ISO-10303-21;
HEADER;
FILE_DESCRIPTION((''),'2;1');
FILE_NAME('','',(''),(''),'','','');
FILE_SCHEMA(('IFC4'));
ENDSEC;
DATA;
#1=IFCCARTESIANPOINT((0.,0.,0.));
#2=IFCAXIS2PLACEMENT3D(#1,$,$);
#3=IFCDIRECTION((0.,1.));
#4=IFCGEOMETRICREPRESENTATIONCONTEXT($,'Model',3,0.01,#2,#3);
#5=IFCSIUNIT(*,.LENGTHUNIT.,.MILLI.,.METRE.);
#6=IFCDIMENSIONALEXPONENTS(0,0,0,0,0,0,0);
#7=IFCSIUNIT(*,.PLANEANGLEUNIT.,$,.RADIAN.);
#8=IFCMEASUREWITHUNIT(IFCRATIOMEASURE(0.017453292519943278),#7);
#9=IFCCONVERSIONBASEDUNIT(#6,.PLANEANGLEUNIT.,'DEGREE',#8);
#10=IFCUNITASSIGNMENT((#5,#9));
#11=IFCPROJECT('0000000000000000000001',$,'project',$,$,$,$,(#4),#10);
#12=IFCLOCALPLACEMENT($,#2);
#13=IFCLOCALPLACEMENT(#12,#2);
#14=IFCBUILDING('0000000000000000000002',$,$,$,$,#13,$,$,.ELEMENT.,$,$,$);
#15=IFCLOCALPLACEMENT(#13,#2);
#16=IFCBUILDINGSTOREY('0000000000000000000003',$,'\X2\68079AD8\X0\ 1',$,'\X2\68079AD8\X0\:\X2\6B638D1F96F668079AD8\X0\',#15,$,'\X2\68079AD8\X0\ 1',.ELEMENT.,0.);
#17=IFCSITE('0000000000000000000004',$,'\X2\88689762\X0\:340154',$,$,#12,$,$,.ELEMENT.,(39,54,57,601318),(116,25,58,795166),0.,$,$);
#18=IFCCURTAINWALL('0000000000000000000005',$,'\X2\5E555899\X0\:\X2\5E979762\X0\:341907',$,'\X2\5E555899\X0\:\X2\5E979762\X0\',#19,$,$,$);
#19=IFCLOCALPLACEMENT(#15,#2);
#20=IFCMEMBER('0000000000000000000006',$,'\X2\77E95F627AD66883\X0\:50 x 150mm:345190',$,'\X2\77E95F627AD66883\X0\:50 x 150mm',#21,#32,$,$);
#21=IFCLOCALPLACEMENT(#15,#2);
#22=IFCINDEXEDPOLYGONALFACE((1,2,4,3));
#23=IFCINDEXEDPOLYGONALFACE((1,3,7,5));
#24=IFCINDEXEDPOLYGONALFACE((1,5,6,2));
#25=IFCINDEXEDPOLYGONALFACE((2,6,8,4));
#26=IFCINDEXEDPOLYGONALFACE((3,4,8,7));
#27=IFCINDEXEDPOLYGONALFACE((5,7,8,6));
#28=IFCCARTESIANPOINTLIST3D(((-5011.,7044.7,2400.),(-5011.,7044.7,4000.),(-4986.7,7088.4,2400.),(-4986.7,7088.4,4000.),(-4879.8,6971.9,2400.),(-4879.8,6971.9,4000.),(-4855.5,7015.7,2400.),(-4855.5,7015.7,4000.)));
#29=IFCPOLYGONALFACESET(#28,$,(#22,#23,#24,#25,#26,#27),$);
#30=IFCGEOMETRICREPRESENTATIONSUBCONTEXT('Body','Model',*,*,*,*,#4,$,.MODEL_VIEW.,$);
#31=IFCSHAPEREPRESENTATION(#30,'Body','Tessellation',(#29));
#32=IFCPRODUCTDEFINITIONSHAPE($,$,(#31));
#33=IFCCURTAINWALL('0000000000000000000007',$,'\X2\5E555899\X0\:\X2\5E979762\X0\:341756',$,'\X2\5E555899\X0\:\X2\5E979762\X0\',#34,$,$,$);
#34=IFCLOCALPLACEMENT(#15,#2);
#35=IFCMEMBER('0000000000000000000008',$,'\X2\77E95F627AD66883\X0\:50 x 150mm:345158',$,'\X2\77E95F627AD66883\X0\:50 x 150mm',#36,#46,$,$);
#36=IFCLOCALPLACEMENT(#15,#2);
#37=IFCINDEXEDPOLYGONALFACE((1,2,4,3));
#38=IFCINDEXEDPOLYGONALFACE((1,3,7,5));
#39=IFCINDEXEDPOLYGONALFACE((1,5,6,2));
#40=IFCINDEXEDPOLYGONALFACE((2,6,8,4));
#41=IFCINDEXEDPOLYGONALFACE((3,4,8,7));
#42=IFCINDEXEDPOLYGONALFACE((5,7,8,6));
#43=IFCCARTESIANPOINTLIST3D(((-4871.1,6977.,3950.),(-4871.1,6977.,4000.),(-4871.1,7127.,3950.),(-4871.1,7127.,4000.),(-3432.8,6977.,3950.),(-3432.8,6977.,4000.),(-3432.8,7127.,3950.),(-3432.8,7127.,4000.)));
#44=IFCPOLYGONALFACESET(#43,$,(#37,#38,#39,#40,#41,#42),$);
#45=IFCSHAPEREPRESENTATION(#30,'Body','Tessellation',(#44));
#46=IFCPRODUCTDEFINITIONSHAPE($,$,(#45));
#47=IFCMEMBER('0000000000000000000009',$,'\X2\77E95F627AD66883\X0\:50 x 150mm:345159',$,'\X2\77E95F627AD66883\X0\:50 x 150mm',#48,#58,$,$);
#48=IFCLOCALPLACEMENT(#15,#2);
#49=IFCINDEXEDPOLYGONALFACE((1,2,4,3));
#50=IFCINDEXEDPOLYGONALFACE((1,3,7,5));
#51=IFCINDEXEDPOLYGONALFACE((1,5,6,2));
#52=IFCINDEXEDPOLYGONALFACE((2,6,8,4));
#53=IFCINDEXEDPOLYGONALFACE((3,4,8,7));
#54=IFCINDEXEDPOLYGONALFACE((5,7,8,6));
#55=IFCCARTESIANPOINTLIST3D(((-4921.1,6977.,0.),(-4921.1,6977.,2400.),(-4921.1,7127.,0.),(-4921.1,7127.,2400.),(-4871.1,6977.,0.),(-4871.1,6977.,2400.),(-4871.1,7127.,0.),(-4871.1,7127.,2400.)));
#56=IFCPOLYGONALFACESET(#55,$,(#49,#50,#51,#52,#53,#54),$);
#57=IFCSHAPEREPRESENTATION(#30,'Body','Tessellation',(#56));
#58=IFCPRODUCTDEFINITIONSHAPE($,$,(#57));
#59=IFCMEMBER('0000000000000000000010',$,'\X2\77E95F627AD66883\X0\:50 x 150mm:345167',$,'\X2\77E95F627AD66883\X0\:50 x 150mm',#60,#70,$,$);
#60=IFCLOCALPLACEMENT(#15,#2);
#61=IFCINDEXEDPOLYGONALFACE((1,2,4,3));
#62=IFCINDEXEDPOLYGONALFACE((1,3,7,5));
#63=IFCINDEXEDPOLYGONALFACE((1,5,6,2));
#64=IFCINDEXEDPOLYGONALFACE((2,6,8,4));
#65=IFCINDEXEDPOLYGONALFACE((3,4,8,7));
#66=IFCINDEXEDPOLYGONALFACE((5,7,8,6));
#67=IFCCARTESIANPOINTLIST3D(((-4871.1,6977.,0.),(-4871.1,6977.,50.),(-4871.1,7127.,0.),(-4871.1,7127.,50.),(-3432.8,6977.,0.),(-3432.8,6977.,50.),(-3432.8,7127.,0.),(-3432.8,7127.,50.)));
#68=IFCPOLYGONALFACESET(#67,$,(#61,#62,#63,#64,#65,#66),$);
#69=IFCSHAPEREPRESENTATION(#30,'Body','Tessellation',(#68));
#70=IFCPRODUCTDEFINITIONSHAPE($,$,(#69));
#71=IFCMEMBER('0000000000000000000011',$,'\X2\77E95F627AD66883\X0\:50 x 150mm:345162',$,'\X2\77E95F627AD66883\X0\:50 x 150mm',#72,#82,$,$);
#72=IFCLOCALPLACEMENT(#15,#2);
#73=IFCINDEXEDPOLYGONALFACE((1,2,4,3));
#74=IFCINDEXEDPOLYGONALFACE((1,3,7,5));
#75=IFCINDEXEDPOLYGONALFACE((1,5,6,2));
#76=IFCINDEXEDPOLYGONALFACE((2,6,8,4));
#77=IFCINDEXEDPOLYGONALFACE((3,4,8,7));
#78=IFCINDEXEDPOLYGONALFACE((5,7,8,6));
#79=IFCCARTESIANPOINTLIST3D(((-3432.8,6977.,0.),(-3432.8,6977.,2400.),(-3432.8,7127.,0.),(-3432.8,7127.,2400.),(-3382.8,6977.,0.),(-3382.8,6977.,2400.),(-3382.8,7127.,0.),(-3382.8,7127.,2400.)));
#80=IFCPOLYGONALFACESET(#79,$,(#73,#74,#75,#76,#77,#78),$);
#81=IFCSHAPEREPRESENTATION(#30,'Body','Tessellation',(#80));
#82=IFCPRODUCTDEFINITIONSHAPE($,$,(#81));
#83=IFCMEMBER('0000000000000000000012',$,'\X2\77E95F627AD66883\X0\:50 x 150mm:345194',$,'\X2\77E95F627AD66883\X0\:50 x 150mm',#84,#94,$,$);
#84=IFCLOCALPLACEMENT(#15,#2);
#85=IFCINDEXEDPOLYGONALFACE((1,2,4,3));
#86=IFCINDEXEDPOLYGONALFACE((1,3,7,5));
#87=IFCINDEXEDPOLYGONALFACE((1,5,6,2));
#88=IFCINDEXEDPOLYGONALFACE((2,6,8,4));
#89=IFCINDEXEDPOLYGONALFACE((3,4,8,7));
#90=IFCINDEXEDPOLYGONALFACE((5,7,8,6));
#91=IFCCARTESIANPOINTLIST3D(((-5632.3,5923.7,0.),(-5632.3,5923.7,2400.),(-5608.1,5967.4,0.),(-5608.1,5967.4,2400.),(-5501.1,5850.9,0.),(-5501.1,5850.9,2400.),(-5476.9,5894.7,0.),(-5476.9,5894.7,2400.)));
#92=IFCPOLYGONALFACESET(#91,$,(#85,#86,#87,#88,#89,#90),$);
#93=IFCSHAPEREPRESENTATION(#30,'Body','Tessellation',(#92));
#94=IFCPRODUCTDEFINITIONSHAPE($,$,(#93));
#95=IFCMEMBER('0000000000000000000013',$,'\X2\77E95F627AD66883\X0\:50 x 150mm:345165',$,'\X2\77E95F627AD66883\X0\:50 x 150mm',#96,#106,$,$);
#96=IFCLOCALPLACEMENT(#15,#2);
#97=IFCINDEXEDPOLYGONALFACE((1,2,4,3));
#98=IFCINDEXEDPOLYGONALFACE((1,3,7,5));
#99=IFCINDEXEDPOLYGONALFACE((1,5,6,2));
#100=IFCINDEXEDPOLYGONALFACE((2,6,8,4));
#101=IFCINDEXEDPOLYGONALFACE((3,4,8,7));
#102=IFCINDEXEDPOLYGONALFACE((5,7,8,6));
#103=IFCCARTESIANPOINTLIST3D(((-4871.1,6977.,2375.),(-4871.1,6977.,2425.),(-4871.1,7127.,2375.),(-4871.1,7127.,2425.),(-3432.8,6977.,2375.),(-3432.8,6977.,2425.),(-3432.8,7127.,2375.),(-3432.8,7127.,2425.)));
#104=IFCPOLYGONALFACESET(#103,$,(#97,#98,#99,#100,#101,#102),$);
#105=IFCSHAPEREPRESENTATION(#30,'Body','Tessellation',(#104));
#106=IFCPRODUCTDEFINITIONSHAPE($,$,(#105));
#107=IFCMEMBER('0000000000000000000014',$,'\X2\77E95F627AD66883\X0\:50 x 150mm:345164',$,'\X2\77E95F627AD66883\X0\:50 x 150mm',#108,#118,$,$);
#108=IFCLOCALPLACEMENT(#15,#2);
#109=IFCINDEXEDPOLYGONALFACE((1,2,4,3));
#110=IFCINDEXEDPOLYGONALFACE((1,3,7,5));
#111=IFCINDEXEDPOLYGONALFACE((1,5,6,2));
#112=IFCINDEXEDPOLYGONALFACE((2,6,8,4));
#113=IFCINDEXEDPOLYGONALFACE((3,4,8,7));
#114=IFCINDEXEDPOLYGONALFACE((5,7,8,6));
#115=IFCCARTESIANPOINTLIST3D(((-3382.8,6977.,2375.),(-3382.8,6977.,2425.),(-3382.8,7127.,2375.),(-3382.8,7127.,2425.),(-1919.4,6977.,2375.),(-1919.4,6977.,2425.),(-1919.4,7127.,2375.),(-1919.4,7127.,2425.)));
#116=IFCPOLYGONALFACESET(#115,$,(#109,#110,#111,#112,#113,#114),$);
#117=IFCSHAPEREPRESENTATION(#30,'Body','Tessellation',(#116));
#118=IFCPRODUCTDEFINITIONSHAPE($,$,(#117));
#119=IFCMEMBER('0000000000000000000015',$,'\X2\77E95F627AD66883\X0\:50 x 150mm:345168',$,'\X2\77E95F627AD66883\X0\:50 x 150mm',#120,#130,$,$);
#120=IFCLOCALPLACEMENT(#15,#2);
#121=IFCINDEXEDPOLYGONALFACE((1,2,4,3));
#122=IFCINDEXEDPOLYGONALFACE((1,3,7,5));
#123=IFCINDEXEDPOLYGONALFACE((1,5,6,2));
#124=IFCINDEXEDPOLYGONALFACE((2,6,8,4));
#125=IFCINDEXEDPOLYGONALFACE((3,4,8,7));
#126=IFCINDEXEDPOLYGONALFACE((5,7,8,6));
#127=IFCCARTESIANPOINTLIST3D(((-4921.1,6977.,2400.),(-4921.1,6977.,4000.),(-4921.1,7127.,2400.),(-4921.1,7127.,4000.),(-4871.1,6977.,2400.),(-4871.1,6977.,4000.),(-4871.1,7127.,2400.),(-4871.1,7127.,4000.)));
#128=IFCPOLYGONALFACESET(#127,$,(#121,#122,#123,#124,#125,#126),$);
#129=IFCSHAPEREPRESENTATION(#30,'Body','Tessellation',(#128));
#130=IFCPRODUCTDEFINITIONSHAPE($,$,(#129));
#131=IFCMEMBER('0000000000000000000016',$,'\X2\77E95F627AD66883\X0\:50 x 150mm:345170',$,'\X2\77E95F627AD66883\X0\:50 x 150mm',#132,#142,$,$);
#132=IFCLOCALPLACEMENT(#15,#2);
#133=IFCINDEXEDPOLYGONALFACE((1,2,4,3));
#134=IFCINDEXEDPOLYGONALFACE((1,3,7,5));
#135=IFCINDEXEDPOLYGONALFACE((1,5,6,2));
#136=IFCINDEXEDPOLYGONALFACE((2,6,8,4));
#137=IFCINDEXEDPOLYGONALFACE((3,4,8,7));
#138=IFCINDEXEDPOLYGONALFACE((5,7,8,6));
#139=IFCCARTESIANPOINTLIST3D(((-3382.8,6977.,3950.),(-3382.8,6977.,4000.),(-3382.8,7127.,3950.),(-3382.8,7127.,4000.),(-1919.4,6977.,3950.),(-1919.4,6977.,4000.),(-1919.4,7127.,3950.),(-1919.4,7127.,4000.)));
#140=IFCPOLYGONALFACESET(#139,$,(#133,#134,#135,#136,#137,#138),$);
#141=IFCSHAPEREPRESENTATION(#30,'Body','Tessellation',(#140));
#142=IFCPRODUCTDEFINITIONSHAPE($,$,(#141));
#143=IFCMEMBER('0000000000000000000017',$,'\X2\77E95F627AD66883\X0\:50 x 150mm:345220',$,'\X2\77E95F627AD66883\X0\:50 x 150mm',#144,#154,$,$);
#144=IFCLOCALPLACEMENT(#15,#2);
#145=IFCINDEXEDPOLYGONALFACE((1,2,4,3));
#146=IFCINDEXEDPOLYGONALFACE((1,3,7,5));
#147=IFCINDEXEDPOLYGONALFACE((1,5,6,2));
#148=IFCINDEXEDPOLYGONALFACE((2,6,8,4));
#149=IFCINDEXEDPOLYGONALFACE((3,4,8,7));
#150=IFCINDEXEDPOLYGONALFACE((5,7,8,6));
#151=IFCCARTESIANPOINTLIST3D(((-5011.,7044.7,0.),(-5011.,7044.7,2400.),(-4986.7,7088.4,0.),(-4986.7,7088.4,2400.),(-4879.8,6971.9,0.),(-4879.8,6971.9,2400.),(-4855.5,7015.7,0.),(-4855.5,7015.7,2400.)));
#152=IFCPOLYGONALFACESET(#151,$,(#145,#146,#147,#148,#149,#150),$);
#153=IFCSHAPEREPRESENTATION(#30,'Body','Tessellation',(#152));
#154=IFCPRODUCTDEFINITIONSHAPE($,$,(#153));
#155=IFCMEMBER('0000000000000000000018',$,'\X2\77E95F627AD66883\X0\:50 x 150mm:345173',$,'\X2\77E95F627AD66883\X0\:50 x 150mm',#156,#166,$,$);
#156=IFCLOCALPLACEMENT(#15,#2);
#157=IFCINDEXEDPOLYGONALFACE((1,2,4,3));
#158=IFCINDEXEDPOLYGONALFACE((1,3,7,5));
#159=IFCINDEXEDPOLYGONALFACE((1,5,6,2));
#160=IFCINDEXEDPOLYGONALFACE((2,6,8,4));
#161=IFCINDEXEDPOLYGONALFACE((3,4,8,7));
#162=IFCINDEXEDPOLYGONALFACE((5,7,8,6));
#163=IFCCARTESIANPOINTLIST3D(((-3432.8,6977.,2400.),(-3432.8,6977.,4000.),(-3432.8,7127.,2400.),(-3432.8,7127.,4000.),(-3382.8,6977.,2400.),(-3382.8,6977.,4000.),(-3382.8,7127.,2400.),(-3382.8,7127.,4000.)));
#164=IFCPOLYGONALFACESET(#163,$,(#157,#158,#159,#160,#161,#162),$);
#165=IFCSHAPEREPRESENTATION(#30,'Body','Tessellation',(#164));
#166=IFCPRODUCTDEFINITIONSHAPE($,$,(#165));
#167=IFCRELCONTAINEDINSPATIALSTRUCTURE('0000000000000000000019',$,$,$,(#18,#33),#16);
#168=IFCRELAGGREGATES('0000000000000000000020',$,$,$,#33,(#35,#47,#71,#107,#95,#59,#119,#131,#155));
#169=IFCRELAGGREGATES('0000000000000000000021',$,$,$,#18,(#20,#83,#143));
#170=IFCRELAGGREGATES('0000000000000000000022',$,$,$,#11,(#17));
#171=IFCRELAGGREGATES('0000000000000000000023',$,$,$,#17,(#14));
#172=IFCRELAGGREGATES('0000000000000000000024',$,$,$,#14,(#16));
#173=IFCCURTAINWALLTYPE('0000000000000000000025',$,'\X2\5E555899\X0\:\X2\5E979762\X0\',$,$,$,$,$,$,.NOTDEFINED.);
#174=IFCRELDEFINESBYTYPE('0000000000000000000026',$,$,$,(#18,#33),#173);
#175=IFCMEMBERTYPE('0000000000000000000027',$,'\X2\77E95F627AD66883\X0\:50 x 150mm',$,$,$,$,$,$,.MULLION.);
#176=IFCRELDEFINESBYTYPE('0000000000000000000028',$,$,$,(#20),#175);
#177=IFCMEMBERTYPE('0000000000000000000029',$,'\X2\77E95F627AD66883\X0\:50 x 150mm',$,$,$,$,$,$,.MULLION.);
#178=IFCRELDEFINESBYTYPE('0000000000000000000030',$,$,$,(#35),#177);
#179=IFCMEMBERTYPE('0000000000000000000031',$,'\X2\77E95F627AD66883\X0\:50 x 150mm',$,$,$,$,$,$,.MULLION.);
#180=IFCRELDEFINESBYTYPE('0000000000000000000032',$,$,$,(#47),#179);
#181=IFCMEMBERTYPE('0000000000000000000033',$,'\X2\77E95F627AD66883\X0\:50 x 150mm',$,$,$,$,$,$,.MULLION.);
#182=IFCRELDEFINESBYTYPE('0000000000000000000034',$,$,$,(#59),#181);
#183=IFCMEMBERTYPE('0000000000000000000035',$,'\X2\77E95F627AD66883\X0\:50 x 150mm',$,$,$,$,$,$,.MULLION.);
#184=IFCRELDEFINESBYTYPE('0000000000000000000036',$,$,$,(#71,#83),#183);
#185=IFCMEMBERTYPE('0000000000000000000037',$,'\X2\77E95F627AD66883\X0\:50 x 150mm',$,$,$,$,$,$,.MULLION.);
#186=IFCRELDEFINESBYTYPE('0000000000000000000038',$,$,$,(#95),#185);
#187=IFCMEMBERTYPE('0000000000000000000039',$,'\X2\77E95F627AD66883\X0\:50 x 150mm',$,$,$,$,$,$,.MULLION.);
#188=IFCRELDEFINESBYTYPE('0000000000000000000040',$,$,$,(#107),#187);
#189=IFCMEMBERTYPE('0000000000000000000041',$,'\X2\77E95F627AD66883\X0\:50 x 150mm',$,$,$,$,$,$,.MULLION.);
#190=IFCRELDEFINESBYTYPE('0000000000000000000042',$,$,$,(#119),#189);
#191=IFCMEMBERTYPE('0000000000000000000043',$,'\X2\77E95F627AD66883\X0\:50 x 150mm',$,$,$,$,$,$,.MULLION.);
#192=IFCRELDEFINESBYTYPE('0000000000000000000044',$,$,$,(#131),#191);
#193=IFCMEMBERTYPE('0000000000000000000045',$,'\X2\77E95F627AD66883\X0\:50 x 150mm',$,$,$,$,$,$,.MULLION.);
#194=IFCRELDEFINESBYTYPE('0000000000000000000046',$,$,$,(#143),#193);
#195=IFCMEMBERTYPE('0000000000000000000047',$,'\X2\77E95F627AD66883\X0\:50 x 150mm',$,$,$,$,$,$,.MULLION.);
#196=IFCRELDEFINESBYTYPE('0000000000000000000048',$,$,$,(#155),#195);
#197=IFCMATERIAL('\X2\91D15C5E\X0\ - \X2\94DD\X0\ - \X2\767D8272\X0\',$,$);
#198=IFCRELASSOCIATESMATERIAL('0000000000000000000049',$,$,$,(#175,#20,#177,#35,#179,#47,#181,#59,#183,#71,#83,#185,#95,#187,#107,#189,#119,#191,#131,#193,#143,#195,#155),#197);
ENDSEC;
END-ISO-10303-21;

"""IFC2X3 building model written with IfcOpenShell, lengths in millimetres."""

from ifc_helpers import new_model, entity, si_unit, converted_unit, direction, frame, origin, origin_2d_with_axis, place, context, subcontext, project, spatial, rectangle, extrude, source, transform, mapped, material, type_object, type_shapes, element, aggregate, save


model = new_model("IFC2X3")

# Units and contexts
model_context = context("Model", 3, precision=0.01, world=origin(), true_north=direction((0.0, 1.0)))
body_context = subcontext(model_context, "Body", "Model", "MODEL_VIEW")
ifc_project = project(units=[si_unit("LENGTHUNIT", "METRE", prefix="MILLI"), converted_unit("PLANEANGLEUNIT", "DEGREE", entity("IfcRatioMeasure", 0.017453292519943278), si_unit("PLANEANGLEUNIT", "RADIAN"), dimensions=[0, 0, 0, 0, 0, 0, 0])], contexts=[model_context])

# Site, building, storey
site_placement = place(None, origin())
site = spatial("IfcSite", under=ifc_project, at=site_placement, Name="表面:340154", CompositionType="ELEMENT", RefLatitude=(39, 54, 57, 601318), RefLongitude=(116, 25, 58, 795166), RefElevation=0.0)
building_placement = place(site_placement, origin())
building = spatial("IfcBuilding", under=site, at=building_placement, CompositionType="ELEMENT")
storey_placement = place(building_placement, origin())
storey = spatial("IfcBuildingStorey", under=building, at=storey_placement, Name="标高 1", ObjectType="标高:正负零标高", LongName="标高 1", CompositionType="ELEMENT", Elevation=0.0)

# Curtain wall, member
curtain_wall_type = type_object("IfcCurtainWallType", Name="幕墙:店面", PredefinedType="NOTDEFINED")
curtain_wall_1_placement = place(storey_placement, origin())
curtain_wall_1 = element("IfcCurtainWall", 1, at=curtain_wall_1_placement, inside=storey, type_object=curtain_wall_type, Name="幕墙:店面:341907", ObjectType="幕墙:店面")
ifc_material_1 = material(Name="金属 - 铝 - 白色")
member_type_1 = type_object("IfcMemberType", Name="矩形竖梃:50 x 150mm", PredefinedType="MULLION", material=ifc_material_1)
shared_shape_1 = source(origin(), body_context, "Body", "SweptSolid", [
    extrude(rectangle(XDim=150.0, YDim=50.0, at=origin_2d_with_axis()), frame((-25.0, 0.0, -1600.0), z_axis=(0.0, 0.0, 1.0), x_axis=(0.0, -1.0, 0.0)), (0.0, 0.0, 1.0), 1600.0),
])
type_shapes(member_type_1, [shared_shape_1])
member_1_placement = place(curtain_wall_1_placement, frame((-4921.1, 7052.0, 4000.0), z_axis=(0.0, 0.0, 1.0), x_axis=(0.48481, 0.87462, 0.0)))
member_1 = element("IfcMember", 2, at=member_1_placement, type_object=member_type_1, material=ifc_material_1, Name="矩形竖梃:50 x 150mm:345190", ObjectType="矩形竖梃:50 x 150mm", context=body_context, shape_type="MappedRepresentation", body=[
    mapped(shared_shape_1, transform((0.0, 0.0, 0.0), scale=1.0)),
])

# Curtain wall, members
curtain_wall_2_placement = place(storey_placement, origin())
curtain_wall_2 = element("IfcCurtainWall", 3, at=curtain_wall_2_placement, inside=storey, type_object=curtain_wall_type, Name="幕墙:店面:341756", ObjectType="幕墙:店面")
member_type_2 = type_object("IfcMemberType", Name="矩形竖梃:50 x 150mm", PredefinedType="MULLION", material=ifc_material_1)
shared_shape_2 = source(origin(), body_context, "Body", "SweptSolid", [
    extrude(rectangle(XDim=150.0, YDim=50.0, at=origin_2d_with_axis()), frame((-25.0, 0.0, -1438.3), z_axis=(0.0, 0.0, 1.0), x_axis=(0.0, -1.0, 0.0)), (0.0, 0.0, 1.0), 1438.3),
])
type_shapes(member_type_2, [shared_shape_2])
member_2_placement = place(curtain_wall_2_placement, frame((-4871.1, 7052.0, 4000.0), z_axis=(-1.0, 0.0, 0.0), x_axis=(0.0, 0.0, 1.0)))
member_2 = element("IfcMember", 4, at=member_2_placement, type_object=member_type_2, material=ifc_material_1, Name="矩形竖梃:50 x 150mm:345158", ObjectType="矩形竖梃:50 x 150mm", context=body_context, shape_type="MappedRepresentation", body=[
    mapped(shared_shape_2, transform((0.0, 0.0, 0.0), scale=1.0)),
])
member_type_3 = type_object("IfcMemberType", Name="矩形竖梃:50 x 150mm", PredefinedType="MULLION", material=ifc_material_1)
shared_shape_3 = source(origin(), body_context, "Body", "SweptSolid", [
    extrude(rectangle(XDim=150.0, YDim=50.0, at=origin_2d_with_axis()), frame((-25.0, 0.0, -2400.0), z_axis=(0.0, 0.0, 1.0), x_axis=(0.0, -1.0, 0.0)), (0.0, 0.0, 1.0), 2400.0),
])
type_shapes(member_type_3, [shared_shape_3])
member_3_placement = place(curtain_wall_2_placement, frame((-4921.1, 7052.0, 0.0), z_axis=(0.0, 0.0, -1.0), x_axis=(-1.0, 0.0, 0.0)))
member_3 = element("IfcMember", 5, at=member_3_placement, type_object=member_type_3, material=ifc_material_1, Name="矩形竖梃:50 x 150mm:345159", ObjectType="矩形竖梃:50 x 150mm", context=body_context, shape_type="MappedRepresentation", body=[
    mapped(shared_shape_3, transform((0.0, 0.0, 0.0), scale=1.0)),
])
member_type_4 = type_object("IfcMemberType", Name="矩形竖梃:50 x 150mm", PredefinedType="MULLION", material=ifc_material_1)
shared_shape_4 = source(origin(), body_context, "Body", "SweptSolid", [
    extrude(rectangle(XDim=150.0, YDim=50.0, at=origin_2d_with_axis()), frame((-25.0, 0.0, -1438.3), z_axis=(0.0, 0.0, 1.0), x_axis=(0.0, -1.0, 0.0)), (0.0, 0.0, 1.0), 1438.3),
])
type_shapes(member_type_4, [shared_shape_4])
member_4_placement = place(curtain_wall_2_placement, frame((-3432.8, 7052.0, 0.0), z_axis=(1.0, 0.0, 0.0), x_axis=(0.0, 0.0, -1.0)))
member_4 = element("IfcMember", 6, at=member_4_placement, type_object=member_type_4, material=ifc_material_1, Name="矩形竖梃:50 x 150mm:345167", ObjectType="矩形竖梃:50 x 150mm", context=body_context, shape_type="MappedRepresentation", body=[
    mapped(shared_shape_4, transform((0.0, 0.0, 0.0), scale=1.0)),
])
member_type_5 = type_object("IfcMemberType", Name="矩形竖梃:50 x 150mm", PredefinedType="MULLION", material=ifc_material_1)
shared_shape_5 = source(origin(), body_context, "Body", "SweptSolid", [
    extrude(rectangle(XDim=150.0, YDim=50.0, at=origin_2d_with_axis()), frame((0.0, 0.0, -2400.0), z_axis=(0.0, 0.0, 1.0), x_axis=(0.0, -1.0, 0.0)), (0.0, 0.0, 1.0), 2400.0),
])
type_shapes(member_type_5, [shared_shape_5])
member_5_placement = place(curtain_wall_2_placement, frame((-3407.8, 7052.0, 0.0), z_axis=(0.0, 0.0, -1.0), x_axis=(-1.0, 0.0, 0.0)))
member_5 = element("IfcMember", 7, at=member_5_placement, type_object=member_type_5, material=ifc_material_1, Name="矩形竖梃:50 x 150mm:345162", ObjectType="矩形竖梃:50 x 150mm", context=body_context, shape_type="MappedRepresentation", body=[
    mapped(shared_shape_5, transform((0.0, 0.0, 0.0), scale=1.0)),
])

# Members
member_6_placement = place(curtain_wall_1_placement, frame((-5554.6, 5909.2, 0.0), z_axis=(0.0, 0.0, -1.0), x_axis=(-0.48481, -0.87462, 0.0)))
member_6 = element("IfcMember", 8, at=member_6_placement, type_object=member_type_5, material=ifc_material_1, Name="矩形竖梃:50 x 150mm:345194", ObjectType="矩形竖梃:50 x 150mm", context=body_context, shape_type="MappedRepresentation", body=[
    mapped(shared_shape_5, transform((0.0, 0.0, 0.0), scale=1.0)),
])
member_type_6 = type_object("IfcMemberType", Name="矩形竖梃:50 x 150mm", PredefinedType="MULLION", material=ifc_material_1)
shared_shape_6 = source(origin(), body_context, "Body", "SweptSolid", [
    extrude(rectangle(XDim=150.0, YDim=50.0, at=origin_2d_with_axis()), frame((0.0, 0.0, -1438.3), z_axis=(0.0, 0.0, 1.0), x_axis=(0.0, -1.0, 0.0)), (0.0, 0.0, 1.0), 1438.3),
])
type_shapes(member_type_6, [shared_shape_6])
member_7_placement = place(curtain_wall_2_placement, frame((-4871.1, 7052.0, 2400.0), z_axis=(-1.0, 0.0, 0.0), x_axis=(0.0, 0.0, 1.0)))
member_7 = element("IfcMember", 9, at=member_7_placement, type_object=member_type_6, material=ifc_material_1, Name="矩形竖梃:50 x 150mm:345165", ObjectType="矩形竖梃:50 x 150mm", context=body_context, shape_type="MappedRepresentation", body=[
    mapped(shared_shape_6, transform((0.0, 0.0, 0.0), scale=1.0)),
])
member_type_7 = type_object("IfcMemberType", Name="矩形竖梃:50 x 150mm", PredefinedType="MULLION", material=ifc_material_1)
shared_shape_7 = source(origin(), body_context, "Body", "SweptSolid", [
    extrude(rectangle(XDim=150.0, YDim=50.0, at=origin_2d_with_axis()), frame((0.0, 0.0, -1463.3), z_axis=(0.0, 0.0, 1.0), x_axis=(0.0, -1.0, 0.0)), (0.0, 0.0, 1.0), 1463.3),
])
type_shapes(member_type_7, [shared_shape_7])
member_8_placement = place(curtain_wall_2_placement, frame((-3382.8, 7052.0, 2400.0), z_axis=(-1.0, 0.0, 0.0), x_axis=(0.0, 0.0, 1.0)))
member_8 = element("IfcMember", 10, at=member_8_placement, type_object=member_type_7, material=ifc_material_1, Name="矩形竖梃:50 x 150mm:345164", ObjectType="矩形竖梃:50 x 150mm", context=body_context, shape_type="MappedRepresentation", body=[
    mapped(shared_shape_7, transform((0.0, 0.0, 0.0), scale=1.0)),
])
member_type_8 = type_object("IfcMemberType", Name="矩形竖梃:50 x 150mm", PredefinedType="MULLION", material=ifc_material_1)
shared_shape_8 = source(origin(), body_context, "Body", "SweptSolid", [
    extrude(rectangle(XDim=150.0, YDim=50.0, at=origin_2d_with_axis()), frame((-25.0, 0.0, -1600.0), z_axis=(0.0, 0.0, 1.0), x_axis=(0.0, -1.0, 0.0)), (0.0, 0.0, 1.0), 1600.0),
])
type_shapes(member_type_8, [shared_shape_8])
member_9_placement = place(curtain_wall_2_placement, frame((-4921.1, 7052.0, 2400.0), z_axis=(0.0, 0.0, -1.0), x_axis=(-1.0, 0.0, 0.0)))
member_9 = element("IfcMember", 11, at=member_9_placement, type_object=member_type_8, material=ifc_material_1, Name="矩形竖梃:50 x 150mm:345168", ObjectType="矩形竖梃:50 x 150mm", context=body_context, shape_type="MappedRepresentation", body=[
    mapped(shared_shape_8, transform((0.0, 0.0, 0.0), scale=1.0)),
])
member_type_9 = type_object("IfcMemberType", Name="矩形竖梃:50 x 150mm", PredefinedType="MULLION", material=ifc_material_1)
shared_shape_9 = source(origin(), body_context, "Body", "SweptSolid", [
    extrude(rectangle(XDim=150.0, YDim=50.0, at=origin_2d_with_axis()), frame((-25.0, 0.0, -1463.3), z_axis=(0.0, 0.0, 1.0), x_axis=(0.0, -1.0, 0.0)), (0.0, 0.0, 1.0), 1463.3),
])
type_shapes(member_type_9, [shared_shape_9])
member_10_placement = place(curtain_wall_2_placement, frame((-3382.8, 7052.0, 4000.0), z_axis=(-1.0, 0.0, 0.0), x_axis=(0.0, 0.0, 1.0)))
member_10 = element("IfcMember", 12, at=member_10_placement, type_object=member_type_9, material=ifc_material_1, Name="矩形竖梃:50 x 150mm:345170", ObjectType="矩形竖梃:50 x 150mm", context=body_context, shape_type="MappedRepresentation", body=[
    mapped(shared_shape_9, transform((0.0, 0.0, 0.0), scale=1.0)),
])
member_type_10 = type_object("IfcMemberType", Name="矩形竖梃:50 x 150mm", PredefinedType="MULLION", material=ifc_material_1)
shared_shape_10 = source(origin(), body_context, "Body", "SweptSolid", [
    extrude(rectangle(XDim=150.0, YDim=50.0, at=origin_2d_with_axis()), frame((-25.0, 0.0, -2400.0), z_axis=(0.0, 0.0, 1.0), x_axis=(0.0, -1.0, 0.0)), (0.0, 0.0, 1.0), 2400.0),
])
type_shapes(member_type_10, [shared_shape_10])
member_11_placement = place(curtain_wall_1_placement, frame((-4921.1, 7052.0, 2400.0), z_axis=(0.0, 0.0, 1.0), x_axis=(0.48481, 0.87462, 0.0)))
member_11 = element("IfcMember", 13, at=member_11_placement, type_object=member_type_10, material=ifc_material_1, Name="矩形竖梃:50 x 150mm:345220", ObjectType="矩形竖梃:50 x 150mm", context=body_context, shape_type="MappedRepresentation", body=[
    mapped(shared_shape_10, transform((0.0, 0.0, 0.0), scale=1.0)),
])
member_type_11 = type_object("IfcMemberType", Name="矩形竖梃:50 x 150mm", PredefinedType="MULLION", material=ifc_material_1)
shared_shape_11 = source(origin(), body_context, "Body", "SweptSolid", [
    extrude(rectangle(XDim=150.0, YDim=50.0, at=origin_2d_with_axis()), frame((0.0, 0.0, -1600.0), z_axis=(0.0, 0.0, 1.0), x_axis=(0.0, -1.0, 0.0)), (0.0, 0.0, 1.0), 1600.0),
])
type_shapes(member_type_11, [shared_shape_11])
member_12_placement = place(curtain_wall_2_placement, frame((-3407.8, 7052.0, 2400.0), z_axis=(0.0, 0.0, -1.0), x_axis=(-1.0, 0.0, 0.0)))
member_12 = element("IfcMember", 14, at=member_12_placement, type_object=member_type_11, material=ifc_material_1, Name="矩形竖梃:50 x 150mm:345173", ObjectType="矩形竖梃:50 x 150mm", context=body_context, shape_type="MappedRepresentation", body=[
    mapped(shared_shape_11, transform((0.0, 0.0, 0.0), scale=1.0)),
])

aggregate(curtain_wall_2, [member_2, member_3, member_5, member_8, member_7, member_4, member_9, member_10, member_12])
aggregate(curtain_wall_1, [member_1, member_6, member_11])

save(model, "model.ifc")
